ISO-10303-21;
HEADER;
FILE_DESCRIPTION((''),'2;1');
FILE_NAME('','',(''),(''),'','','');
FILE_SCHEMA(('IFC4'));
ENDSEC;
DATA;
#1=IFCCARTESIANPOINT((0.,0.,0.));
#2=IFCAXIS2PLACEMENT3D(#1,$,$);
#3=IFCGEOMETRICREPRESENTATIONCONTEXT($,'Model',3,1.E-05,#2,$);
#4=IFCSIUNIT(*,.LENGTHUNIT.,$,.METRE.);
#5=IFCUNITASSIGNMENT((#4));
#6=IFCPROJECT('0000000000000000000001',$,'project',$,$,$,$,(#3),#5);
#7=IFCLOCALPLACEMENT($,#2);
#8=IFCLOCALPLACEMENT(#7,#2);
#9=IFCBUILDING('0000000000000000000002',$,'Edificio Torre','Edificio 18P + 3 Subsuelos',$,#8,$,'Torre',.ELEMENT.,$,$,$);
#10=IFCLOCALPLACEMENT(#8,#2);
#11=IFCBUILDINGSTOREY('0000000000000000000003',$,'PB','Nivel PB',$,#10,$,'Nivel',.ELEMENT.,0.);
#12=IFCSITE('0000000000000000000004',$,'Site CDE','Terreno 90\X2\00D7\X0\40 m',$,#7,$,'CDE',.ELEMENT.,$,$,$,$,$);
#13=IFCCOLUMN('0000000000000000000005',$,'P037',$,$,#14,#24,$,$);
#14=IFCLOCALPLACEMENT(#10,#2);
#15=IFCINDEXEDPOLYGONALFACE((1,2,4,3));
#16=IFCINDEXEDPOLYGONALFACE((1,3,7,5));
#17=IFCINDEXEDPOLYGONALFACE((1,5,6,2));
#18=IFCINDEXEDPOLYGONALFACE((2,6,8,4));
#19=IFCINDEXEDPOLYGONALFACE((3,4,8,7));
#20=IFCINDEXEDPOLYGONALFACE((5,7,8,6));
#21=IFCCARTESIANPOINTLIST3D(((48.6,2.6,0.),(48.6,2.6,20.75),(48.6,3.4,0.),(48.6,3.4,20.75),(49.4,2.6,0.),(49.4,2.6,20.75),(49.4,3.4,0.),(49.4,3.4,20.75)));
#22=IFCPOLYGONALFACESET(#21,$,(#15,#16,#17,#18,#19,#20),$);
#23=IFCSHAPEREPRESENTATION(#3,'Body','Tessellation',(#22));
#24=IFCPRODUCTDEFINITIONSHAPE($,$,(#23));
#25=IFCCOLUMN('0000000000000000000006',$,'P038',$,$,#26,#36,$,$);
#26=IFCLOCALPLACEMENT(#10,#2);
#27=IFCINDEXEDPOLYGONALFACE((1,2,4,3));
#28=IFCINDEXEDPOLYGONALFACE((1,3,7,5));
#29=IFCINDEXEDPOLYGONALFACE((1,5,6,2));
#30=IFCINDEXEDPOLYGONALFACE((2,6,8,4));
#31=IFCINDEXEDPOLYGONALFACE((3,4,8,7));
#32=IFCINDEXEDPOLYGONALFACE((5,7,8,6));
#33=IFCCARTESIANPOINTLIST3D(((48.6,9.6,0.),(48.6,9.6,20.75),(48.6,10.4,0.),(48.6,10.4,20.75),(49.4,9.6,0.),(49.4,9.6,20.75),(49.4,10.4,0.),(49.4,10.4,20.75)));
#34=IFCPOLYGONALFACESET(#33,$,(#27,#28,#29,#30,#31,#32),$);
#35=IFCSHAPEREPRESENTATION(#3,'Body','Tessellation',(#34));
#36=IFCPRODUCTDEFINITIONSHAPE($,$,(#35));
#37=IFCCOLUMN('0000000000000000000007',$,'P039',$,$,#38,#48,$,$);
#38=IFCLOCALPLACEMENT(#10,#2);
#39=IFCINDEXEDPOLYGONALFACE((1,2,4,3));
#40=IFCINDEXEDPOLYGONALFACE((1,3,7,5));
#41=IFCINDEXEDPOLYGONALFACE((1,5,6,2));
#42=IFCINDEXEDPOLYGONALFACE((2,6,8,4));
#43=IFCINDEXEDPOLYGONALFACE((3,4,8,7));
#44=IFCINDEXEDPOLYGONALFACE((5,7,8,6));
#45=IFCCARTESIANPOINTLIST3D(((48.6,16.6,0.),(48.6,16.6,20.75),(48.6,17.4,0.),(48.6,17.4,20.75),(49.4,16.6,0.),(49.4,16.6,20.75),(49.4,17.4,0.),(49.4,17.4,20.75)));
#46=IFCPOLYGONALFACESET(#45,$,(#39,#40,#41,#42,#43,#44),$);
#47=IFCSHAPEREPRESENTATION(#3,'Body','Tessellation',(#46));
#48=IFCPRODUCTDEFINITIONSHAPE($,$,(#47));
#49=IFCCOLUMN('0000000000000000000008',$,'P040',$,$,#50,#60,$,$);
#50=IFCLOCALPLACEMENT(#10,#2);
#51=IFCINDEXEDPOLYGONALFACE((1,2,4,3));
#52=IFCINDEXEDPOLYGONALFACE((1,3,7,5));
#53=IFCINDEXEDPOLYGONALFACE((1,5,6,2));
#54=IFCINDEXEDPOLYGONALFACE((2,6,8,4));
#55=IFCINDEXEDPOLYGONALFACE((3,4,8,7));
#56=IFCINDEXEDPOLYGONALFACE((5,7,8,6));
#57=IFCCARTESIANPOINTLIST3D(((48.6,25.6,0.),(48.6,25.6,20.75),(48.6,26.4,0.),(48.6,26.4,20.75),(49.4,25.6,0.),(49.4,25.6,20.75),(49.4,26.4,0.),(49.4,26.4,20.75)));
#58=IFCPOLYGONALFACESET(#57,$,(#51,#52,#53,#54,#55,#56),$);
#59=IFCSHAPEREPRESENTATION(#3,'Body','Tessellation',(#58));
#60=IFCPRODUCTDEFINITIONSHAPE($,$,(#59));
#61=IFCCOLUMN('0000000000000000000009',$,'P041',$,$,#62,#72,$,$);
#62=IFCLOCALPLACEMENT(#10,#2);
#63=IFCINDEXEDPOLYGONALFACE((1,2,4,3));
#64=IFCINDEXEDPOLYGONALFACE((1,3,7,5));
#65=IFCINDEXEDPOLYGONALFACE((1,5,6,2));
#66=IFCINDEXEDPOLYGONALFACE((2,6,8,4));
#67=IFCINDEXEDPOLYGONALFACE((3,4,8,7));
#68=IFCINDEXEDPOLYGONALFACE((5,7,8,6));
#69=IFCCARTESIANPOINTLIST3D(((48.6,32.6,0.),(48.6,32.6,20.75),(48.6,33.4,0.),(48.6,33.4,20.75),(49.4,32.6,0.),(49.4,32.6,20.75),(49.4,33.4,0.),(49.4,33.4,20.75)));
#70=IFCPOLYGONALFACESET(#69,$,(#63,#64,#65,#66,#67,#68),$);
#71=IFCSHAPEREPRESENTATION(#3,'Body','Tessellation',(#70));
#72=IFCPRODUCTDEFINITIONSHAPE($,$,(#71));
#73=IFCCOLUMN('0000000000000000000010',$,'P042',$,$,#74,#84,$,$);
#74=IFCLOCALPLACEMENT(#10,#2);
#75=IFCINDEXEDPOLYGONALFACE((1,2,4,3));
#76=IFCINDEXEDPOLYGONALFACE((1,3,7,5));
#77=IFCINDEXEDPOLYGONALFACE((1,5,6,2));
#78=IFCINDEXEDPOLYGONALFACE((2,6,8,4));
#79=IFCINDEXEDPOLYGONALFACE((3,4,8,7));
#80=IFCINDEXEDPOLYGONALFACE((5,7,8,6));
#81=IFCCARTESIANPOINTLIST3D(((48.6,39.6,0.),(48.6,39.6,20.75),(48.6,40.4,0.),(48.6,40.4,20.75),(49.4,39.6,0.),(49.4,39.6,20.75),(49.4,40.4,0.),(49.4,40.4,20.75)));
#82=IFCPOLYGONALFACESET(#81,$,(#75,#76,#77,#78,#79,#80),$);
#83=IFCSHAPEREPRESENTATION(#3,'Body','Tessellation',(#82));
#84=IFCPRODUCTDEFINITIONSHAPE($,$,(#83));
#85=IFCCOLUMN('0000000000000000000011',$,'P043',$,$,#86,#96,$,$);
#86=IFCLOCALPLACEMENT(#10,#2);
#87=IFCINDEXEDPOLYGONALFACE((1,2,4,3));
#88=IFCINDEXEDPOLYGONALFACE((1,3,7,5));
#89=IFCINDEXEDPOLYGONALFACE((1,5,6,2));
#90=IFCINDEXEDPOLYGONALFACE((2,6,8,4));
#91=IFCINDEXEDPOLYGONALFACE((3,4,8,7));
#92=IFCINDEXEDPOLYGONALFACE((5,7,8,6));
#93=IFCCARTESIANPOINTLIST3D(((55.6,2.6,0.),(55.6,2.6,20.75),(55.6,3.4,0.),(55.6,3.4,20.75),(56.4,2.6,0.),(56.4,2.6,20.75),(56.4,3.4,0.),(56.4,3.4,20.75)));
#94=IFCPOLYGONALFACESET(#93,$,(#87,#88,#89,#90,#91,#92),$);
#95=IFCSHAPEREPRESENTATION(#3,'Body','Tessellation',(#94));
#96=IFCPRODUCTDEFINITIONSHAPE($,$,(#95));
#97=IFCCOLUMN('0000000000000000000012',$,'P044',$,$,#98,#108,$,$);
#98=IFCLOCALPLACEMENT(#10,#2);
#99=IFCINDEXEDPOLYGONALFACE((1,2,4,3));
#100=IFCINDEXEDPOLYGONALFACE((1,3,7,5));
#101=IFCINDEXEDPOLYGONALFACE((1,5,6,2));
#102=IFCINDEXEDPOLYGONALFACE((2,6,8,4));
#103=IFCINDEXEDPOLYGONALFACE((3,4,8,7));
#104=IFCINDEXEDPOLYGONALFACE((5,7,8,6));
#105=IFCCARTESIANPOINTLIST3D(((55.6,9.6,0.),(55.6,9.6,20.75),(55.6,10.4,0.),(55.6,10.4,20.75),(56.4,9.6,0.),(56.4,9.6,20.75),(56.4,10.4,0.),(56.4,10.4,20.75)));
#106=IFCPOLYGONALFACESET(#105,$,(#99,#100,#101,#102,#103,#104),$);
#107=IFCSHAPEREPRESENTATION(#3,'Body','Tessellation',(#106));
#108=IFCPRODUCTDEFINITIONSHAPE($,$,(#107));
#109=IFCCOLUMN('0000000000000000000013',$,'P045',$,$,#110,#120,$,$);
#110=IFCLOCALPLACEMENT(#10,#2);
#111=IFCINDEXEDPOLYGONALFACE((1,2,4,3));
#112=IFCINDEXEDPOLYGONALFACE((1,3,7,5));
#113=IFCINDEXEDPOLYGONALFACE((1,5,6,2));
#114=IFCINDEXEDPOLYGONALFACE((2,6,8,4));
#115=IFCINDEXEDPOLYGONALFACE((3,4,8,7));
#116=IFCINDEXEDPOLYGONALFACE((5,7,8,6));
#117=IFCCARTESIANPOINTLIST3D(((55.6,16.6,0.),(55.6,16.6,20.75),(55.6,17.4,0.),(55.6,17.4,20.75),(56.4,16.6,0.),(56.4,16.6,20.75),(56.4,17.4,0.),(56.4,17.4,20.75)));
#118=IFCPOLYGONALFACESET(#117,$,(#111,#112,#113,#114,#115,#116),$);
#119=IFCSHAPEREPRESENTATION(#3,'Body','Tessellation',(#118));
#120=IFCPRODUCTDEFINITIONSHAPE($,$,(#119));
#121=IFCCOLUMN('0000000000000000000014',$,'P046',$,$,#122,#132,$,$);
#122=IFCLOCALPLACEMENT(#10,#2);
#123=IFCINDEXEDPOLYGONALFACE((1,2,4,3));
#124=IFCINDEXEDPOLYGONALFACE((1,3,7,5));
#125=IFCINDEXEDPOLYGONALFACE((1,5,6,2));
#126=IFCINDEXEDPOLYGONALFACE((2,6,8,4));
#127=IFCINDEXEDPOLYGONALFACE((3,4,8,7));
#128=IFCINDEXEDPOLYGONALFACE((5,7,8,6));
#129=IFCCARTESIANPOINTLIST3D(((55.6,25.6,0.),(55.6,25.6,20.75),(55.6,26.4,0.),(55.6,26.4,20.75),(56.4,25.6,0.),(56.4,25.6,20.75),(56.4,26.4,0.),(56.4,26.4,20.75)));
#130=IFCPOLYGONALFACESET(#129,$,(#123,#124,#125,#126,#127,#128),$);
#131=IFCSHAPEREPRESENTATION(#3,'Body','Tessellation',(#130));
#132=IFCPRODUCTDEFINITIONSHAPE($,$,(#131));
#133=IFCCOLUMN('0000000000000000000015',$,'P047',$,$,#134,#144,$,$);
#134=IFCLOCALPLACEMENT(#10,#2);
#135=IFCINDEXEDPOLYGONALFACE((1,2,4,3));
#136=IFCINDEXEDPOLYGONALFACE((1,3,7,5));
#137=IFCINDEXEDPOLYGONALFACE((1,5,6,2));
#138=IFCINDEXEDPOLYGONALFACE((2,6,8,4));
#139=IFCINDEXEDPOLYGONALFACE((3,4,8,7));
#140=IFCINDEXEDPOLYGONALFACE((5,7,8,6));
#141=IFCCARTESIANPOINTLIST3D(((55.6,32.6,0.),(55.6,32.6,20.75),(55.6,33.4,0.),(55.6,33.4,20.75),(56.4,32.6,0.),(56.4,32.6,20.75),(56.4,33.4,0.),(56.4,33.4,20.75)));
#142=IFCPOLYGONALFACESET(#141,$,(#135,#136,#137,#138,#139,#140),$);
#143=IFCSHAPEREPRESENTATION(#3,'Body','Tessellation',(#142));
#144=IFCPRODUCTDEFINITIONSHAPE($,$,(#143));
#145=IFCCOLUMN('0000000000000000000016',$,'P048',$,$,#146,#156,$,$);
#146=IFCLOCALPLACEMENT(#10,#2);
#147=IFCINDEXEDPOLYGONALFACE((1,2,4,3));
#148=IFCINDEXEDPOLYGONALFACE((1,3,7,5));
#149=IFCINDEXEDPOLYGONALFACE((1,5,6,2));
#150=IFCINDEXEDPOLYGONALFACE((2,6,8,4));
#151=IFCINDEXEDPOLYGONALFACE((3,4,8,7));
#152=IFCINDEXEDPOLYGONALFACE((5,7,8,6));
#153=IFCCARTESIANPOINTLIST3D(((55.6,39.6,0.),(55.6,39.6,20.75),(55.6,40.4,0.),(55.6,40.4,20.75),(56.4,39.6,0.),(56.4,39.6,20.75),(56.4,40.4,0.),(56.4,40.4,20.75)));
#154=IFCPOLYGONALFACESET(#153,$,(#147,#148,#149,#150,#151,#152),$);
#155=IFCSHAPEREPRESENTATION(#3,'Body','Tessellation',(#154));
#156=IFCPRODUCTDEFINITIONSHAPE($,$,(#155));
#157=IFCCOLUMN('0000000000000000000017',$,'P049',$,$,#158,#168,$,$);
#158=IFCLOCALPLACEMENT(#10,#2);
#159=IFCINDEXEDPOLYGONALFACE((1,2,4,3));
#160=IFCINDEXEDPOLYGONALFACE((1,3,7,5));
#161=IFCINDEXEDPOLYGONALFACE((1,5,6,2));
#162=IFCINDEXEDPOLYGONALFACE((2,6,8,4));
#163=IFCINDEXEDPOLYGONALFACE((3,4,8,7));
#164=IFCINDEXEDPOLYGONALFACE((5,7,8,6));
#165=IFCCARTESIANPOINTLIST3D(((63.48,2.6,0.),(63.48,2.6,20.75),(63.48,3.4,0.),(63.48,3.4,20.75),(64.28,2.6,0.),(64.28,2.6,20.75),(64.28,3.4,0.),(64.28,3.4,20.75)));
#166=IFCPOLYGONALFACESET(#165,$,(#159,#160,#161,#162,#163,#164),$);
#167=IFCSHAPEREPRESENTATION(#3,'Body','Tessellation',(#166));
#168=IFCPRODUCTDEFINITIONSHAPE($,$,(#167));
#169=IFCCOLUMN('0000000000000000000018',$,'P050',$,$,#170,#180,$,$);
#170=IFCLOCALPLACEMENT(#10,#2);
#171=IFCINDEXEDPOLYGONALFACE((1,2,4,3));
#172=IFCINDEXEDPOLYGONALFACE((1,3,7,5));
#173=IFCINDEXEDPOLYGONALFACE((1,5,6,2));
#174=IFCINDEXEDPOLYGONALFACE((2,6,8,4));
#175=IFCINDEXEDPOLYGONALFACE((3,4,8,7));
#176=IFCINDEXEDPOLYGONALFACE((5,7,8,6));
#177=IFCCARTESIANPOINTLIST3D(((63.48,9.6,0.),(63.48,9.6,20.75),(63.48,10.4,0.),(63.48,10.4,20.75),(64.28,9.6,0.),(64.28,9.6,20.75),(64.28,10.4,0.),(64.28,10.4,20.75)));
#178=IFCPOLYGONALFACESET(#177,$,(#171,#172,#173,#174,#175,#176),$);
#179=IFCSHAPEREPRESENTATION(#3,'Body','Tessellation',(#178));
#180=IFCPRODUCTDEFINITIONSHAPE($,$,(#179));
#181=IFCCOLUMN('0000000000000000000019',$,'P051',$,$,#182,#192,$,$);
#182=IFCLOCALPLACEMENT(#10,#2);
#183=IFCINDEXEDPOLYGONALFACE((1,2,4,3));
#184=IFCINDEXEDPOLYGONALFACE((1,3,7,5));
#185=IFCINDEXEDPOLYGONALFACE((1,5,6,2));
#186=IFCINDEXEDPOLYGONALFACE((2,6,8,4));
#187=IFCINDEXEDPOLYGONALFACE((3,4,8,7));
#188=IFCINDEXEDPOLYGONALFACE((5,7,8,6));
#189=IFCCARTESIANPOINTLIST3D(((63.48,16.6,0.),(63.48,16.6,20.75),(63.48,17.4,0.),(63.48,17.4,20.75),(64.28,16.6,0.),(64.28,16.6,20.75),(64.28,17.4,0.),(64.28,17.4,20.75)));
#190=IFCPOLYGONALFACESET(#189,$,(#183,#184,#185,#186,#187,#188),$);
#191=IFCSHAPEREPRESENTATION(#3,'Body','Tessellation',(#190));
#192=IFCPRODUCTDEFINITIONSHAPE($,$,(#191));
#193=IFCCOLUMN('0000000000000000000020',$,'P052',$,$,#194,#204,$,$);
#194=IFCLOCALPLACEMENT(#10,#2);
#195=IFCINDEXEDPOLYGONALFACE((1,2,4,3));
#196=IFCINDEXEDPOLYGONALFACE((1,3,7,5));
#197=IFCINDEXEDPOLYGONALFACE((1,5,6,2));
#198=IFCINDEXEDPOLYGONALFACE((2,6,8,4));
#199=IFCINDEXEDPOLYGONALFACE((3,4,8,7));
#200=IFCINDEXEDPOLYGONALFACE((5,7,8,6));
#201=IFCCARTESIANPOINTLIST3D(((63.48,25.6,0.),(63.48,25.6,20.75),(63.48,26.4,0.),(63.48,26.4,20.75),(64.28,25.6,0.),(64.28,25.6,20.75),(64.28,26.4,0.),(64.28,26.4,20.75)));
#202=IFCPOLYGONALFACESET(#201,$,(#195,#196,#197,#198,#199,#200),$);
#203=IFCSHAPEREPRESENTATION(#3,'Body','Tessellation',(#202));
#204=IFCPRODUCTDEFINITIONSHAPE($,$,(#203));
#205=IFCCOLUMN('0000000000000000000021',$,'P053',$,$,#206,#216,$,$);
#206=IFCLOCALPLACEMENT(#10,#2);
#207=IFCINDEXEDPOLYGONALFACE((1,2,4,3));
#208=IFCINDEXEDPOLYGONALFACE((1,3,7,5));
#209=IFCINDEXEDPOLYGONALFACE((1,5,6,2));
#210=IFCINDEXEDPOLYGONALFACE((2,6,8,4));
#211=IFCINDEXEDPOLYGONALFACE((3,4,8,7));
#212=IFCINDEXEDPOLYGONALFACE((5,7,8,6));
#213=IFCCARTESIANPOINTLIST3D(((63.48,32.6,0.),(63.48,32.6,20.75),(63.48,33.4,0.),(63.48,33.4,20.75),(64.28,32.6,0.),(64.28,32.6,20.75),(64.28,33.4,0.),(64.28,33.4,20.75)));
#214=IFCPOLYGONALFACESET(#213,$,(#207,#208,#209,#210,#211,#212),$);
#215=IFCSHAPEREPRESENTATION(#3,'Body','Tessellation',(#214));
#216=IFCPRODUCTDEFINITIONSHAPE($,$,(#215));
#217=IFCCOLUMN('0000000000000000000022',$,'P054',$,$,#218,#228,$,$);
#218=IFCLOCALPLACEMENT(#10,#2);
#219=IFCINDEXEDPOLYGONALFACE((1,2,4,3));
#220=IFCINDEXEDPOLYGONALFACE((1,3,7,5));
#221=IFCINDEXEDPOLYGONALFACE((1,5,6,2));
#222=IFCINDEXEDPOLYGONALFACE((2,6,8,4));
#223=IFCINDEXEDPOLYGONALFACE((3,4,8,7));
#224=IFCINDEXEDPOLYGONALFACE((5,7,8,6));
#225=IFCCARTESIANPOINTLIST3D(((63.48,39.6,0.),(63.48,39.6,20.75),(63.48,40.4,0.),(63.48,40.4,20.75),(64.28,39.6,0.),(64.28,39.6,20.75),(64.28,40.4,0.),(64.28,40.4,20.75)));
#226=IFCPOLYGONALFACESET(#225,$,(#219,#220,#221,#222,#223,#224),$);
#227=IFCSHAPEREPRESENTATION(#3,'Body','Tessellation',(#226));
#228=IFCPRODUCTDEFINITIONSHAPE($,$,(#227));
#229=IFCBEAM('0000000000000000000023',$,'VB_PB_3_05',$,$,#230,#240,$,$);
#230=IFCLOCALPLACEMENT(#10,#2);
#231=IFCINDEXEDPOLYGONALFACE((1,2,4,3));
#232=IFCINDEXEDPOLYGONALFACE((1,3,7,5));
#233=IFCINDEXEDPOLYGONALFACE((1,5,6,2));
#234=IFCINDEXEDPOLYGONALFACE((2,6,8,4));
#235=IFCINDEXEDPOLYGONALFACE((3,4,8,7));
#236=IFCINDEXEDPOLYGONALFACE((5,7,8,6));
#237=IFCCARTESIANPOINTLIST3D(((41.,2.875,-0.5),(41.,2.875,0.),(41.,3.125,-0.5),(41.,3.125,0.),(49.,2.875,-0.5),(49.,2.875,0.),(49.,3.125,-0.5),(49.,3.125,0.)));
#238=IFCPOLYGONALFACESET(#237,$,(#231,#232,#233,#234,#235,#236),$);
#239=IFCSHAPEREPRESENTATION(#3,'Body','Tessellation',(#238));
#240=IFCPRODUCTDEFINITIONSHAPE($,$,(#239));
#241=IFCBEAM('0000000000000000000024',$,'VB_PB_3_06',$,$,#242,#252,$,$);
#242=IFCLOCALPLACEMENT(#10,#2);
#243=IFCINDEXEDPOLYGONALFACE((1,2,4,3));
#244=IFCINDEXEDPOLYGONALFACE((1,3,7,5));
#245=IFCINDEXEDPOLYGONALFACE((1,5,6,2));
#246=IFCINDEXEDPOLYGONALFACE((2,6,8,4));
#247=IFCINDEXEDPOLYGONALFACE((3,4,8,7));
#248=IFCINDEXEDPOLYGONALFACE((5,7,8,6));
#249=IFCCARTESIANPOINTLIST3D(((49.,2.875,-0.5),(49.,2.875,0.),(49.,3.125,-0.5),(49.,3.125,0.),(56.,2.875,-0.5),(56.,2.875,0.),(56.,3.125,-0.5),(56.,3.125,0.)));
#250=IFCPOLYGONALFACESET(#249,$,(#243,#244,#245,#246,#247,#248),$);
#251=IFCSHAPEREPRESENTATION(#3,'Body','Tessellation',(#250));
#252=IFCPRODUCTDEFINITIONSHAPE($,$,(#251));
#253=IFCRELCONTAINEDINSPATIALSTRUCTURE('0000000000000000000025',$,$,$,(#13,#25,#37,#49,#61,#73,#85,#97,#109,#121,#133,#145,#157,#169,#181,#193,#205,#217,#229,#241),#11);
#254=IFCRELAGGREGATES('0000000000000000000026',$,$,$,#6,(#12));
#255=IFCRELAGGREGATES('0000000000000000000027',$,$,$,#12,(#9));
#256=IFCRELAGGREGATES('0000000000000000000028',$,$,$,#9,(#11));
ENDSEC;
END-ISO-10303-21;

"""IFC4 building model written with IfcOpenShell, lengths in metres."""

from ifc_helpers import new_model, si_unit, frame, origin, origin_2d, place, context, project, spatial, rectangle, extrude, element, save


model = new_model("IFC4")

# Units and contexts
model_context = context("Model", 3, precision=1e-05, world=origin())
ifc_project = project(units=[si_unit("LENGTHUNIT", "METRE")], contexts=[model_context])

# Site, building, storey
site_placement = place(None, origin())
site = spatial("IfcSite", under=ifc_project, at=site_placement, Name="Site CDE", Description="Terreno 90×40 m", LongName="CDE", CompositionType="ELEMENT")
building_placement = place(site_placement, origin())
building = spatial("IfcBuilding", under=site, at=building_placement, Name="Edificio Torre", Description="Edificio 18P + 3 Subsuelos", LongName="Torre", CompositionType="ELEMENT")
storey_placement = place(building_placement, origin())
storey = spatial("IfcBuildingStorey", under=building, at=storey_placement, Name="PB", Description="Nivel PB", LongName="Nivel", CompositionType="ELEMENT", Elevation=0.0)

# Columns
for number, where, name in (
    (1, (49.0, 3.0, 0.0), "P037"),
    (2, (49.0, 10.0, 0.0), "P038"),
    (3, (49.0, 17.0, 0.0), "P039"),
    (4, (49.0, 26.0, 0.0), "P040"),
    (5, (49.0, 33.0, 0.0), "P041"),
    (6, (49.0, 40.0, 0.0), "P042"),
    (7, (56.0, 3.0, 0.0), "P043"),
    (8, (56.0, 10.0, 0.0), "P044"),
    (9, (56.0, 17.0, 0.0), "P045"),
    (10, (56.0, 26.0, 0.0), "P046"),
    (11, (56.0, 33.0, 0.0), "P047"),
    (12, (56.0, 40.0, 0.0), "P048"),
    (13, (63.88, 3.0, 0.0), "P049"),
    (14, (63.88, 10.0, 0.0), "P050"),
    (15, (63.88, 17.0, 0.0), "P051"),
    (16, (63.88, 26.0, 0.0), "P052"),
    (17, (63.88, 33.0, 0.0), "P053"),
    (18, (63.88, 40.0, 0.0), "P054"),
):
    element("IfcColumn", number, at=place(storey_placement, frame(where)), inside=storey, Name=name, context=model_context, shape_type="SweptSolid", body=[
        extrude(rectangle(XDim=0.8, YDim=0.8, at=origin_2d()), origin(), (0.0, 0.0, 1.0), 20.75),
    ])

# Beams
beam_1_placement = place(storey_placement, frame((45.0, 3.0, -0.5)))
element("IfcBeam", 19, at=beam_1_placement, inside=storey, Name="VB_PB_3_05", context=model_context, shape_type="SweptSolid", body=[
    extrude(rectangle(XDim=8.0, YDim=0.25, at=origin_2d()), origin(), (0.0, 0.0, 1.0), 0.5),
])
beam_2_placement = place(storey_placement, frame((52.5, 3.0, -0.5)))
element("IfcBeam", 20, at=beam_2_placement, inside=storey, Name="VB_PB_3_06", context=model_context, shape_type="SweptSolid", body=[
    extrude(rectangle(XDim=7.0, YDim=0.25, at=origin_2d()), origin(), (0.0, 0.0, 1.0), 0.5),
])

save(model, "model.ifc")
